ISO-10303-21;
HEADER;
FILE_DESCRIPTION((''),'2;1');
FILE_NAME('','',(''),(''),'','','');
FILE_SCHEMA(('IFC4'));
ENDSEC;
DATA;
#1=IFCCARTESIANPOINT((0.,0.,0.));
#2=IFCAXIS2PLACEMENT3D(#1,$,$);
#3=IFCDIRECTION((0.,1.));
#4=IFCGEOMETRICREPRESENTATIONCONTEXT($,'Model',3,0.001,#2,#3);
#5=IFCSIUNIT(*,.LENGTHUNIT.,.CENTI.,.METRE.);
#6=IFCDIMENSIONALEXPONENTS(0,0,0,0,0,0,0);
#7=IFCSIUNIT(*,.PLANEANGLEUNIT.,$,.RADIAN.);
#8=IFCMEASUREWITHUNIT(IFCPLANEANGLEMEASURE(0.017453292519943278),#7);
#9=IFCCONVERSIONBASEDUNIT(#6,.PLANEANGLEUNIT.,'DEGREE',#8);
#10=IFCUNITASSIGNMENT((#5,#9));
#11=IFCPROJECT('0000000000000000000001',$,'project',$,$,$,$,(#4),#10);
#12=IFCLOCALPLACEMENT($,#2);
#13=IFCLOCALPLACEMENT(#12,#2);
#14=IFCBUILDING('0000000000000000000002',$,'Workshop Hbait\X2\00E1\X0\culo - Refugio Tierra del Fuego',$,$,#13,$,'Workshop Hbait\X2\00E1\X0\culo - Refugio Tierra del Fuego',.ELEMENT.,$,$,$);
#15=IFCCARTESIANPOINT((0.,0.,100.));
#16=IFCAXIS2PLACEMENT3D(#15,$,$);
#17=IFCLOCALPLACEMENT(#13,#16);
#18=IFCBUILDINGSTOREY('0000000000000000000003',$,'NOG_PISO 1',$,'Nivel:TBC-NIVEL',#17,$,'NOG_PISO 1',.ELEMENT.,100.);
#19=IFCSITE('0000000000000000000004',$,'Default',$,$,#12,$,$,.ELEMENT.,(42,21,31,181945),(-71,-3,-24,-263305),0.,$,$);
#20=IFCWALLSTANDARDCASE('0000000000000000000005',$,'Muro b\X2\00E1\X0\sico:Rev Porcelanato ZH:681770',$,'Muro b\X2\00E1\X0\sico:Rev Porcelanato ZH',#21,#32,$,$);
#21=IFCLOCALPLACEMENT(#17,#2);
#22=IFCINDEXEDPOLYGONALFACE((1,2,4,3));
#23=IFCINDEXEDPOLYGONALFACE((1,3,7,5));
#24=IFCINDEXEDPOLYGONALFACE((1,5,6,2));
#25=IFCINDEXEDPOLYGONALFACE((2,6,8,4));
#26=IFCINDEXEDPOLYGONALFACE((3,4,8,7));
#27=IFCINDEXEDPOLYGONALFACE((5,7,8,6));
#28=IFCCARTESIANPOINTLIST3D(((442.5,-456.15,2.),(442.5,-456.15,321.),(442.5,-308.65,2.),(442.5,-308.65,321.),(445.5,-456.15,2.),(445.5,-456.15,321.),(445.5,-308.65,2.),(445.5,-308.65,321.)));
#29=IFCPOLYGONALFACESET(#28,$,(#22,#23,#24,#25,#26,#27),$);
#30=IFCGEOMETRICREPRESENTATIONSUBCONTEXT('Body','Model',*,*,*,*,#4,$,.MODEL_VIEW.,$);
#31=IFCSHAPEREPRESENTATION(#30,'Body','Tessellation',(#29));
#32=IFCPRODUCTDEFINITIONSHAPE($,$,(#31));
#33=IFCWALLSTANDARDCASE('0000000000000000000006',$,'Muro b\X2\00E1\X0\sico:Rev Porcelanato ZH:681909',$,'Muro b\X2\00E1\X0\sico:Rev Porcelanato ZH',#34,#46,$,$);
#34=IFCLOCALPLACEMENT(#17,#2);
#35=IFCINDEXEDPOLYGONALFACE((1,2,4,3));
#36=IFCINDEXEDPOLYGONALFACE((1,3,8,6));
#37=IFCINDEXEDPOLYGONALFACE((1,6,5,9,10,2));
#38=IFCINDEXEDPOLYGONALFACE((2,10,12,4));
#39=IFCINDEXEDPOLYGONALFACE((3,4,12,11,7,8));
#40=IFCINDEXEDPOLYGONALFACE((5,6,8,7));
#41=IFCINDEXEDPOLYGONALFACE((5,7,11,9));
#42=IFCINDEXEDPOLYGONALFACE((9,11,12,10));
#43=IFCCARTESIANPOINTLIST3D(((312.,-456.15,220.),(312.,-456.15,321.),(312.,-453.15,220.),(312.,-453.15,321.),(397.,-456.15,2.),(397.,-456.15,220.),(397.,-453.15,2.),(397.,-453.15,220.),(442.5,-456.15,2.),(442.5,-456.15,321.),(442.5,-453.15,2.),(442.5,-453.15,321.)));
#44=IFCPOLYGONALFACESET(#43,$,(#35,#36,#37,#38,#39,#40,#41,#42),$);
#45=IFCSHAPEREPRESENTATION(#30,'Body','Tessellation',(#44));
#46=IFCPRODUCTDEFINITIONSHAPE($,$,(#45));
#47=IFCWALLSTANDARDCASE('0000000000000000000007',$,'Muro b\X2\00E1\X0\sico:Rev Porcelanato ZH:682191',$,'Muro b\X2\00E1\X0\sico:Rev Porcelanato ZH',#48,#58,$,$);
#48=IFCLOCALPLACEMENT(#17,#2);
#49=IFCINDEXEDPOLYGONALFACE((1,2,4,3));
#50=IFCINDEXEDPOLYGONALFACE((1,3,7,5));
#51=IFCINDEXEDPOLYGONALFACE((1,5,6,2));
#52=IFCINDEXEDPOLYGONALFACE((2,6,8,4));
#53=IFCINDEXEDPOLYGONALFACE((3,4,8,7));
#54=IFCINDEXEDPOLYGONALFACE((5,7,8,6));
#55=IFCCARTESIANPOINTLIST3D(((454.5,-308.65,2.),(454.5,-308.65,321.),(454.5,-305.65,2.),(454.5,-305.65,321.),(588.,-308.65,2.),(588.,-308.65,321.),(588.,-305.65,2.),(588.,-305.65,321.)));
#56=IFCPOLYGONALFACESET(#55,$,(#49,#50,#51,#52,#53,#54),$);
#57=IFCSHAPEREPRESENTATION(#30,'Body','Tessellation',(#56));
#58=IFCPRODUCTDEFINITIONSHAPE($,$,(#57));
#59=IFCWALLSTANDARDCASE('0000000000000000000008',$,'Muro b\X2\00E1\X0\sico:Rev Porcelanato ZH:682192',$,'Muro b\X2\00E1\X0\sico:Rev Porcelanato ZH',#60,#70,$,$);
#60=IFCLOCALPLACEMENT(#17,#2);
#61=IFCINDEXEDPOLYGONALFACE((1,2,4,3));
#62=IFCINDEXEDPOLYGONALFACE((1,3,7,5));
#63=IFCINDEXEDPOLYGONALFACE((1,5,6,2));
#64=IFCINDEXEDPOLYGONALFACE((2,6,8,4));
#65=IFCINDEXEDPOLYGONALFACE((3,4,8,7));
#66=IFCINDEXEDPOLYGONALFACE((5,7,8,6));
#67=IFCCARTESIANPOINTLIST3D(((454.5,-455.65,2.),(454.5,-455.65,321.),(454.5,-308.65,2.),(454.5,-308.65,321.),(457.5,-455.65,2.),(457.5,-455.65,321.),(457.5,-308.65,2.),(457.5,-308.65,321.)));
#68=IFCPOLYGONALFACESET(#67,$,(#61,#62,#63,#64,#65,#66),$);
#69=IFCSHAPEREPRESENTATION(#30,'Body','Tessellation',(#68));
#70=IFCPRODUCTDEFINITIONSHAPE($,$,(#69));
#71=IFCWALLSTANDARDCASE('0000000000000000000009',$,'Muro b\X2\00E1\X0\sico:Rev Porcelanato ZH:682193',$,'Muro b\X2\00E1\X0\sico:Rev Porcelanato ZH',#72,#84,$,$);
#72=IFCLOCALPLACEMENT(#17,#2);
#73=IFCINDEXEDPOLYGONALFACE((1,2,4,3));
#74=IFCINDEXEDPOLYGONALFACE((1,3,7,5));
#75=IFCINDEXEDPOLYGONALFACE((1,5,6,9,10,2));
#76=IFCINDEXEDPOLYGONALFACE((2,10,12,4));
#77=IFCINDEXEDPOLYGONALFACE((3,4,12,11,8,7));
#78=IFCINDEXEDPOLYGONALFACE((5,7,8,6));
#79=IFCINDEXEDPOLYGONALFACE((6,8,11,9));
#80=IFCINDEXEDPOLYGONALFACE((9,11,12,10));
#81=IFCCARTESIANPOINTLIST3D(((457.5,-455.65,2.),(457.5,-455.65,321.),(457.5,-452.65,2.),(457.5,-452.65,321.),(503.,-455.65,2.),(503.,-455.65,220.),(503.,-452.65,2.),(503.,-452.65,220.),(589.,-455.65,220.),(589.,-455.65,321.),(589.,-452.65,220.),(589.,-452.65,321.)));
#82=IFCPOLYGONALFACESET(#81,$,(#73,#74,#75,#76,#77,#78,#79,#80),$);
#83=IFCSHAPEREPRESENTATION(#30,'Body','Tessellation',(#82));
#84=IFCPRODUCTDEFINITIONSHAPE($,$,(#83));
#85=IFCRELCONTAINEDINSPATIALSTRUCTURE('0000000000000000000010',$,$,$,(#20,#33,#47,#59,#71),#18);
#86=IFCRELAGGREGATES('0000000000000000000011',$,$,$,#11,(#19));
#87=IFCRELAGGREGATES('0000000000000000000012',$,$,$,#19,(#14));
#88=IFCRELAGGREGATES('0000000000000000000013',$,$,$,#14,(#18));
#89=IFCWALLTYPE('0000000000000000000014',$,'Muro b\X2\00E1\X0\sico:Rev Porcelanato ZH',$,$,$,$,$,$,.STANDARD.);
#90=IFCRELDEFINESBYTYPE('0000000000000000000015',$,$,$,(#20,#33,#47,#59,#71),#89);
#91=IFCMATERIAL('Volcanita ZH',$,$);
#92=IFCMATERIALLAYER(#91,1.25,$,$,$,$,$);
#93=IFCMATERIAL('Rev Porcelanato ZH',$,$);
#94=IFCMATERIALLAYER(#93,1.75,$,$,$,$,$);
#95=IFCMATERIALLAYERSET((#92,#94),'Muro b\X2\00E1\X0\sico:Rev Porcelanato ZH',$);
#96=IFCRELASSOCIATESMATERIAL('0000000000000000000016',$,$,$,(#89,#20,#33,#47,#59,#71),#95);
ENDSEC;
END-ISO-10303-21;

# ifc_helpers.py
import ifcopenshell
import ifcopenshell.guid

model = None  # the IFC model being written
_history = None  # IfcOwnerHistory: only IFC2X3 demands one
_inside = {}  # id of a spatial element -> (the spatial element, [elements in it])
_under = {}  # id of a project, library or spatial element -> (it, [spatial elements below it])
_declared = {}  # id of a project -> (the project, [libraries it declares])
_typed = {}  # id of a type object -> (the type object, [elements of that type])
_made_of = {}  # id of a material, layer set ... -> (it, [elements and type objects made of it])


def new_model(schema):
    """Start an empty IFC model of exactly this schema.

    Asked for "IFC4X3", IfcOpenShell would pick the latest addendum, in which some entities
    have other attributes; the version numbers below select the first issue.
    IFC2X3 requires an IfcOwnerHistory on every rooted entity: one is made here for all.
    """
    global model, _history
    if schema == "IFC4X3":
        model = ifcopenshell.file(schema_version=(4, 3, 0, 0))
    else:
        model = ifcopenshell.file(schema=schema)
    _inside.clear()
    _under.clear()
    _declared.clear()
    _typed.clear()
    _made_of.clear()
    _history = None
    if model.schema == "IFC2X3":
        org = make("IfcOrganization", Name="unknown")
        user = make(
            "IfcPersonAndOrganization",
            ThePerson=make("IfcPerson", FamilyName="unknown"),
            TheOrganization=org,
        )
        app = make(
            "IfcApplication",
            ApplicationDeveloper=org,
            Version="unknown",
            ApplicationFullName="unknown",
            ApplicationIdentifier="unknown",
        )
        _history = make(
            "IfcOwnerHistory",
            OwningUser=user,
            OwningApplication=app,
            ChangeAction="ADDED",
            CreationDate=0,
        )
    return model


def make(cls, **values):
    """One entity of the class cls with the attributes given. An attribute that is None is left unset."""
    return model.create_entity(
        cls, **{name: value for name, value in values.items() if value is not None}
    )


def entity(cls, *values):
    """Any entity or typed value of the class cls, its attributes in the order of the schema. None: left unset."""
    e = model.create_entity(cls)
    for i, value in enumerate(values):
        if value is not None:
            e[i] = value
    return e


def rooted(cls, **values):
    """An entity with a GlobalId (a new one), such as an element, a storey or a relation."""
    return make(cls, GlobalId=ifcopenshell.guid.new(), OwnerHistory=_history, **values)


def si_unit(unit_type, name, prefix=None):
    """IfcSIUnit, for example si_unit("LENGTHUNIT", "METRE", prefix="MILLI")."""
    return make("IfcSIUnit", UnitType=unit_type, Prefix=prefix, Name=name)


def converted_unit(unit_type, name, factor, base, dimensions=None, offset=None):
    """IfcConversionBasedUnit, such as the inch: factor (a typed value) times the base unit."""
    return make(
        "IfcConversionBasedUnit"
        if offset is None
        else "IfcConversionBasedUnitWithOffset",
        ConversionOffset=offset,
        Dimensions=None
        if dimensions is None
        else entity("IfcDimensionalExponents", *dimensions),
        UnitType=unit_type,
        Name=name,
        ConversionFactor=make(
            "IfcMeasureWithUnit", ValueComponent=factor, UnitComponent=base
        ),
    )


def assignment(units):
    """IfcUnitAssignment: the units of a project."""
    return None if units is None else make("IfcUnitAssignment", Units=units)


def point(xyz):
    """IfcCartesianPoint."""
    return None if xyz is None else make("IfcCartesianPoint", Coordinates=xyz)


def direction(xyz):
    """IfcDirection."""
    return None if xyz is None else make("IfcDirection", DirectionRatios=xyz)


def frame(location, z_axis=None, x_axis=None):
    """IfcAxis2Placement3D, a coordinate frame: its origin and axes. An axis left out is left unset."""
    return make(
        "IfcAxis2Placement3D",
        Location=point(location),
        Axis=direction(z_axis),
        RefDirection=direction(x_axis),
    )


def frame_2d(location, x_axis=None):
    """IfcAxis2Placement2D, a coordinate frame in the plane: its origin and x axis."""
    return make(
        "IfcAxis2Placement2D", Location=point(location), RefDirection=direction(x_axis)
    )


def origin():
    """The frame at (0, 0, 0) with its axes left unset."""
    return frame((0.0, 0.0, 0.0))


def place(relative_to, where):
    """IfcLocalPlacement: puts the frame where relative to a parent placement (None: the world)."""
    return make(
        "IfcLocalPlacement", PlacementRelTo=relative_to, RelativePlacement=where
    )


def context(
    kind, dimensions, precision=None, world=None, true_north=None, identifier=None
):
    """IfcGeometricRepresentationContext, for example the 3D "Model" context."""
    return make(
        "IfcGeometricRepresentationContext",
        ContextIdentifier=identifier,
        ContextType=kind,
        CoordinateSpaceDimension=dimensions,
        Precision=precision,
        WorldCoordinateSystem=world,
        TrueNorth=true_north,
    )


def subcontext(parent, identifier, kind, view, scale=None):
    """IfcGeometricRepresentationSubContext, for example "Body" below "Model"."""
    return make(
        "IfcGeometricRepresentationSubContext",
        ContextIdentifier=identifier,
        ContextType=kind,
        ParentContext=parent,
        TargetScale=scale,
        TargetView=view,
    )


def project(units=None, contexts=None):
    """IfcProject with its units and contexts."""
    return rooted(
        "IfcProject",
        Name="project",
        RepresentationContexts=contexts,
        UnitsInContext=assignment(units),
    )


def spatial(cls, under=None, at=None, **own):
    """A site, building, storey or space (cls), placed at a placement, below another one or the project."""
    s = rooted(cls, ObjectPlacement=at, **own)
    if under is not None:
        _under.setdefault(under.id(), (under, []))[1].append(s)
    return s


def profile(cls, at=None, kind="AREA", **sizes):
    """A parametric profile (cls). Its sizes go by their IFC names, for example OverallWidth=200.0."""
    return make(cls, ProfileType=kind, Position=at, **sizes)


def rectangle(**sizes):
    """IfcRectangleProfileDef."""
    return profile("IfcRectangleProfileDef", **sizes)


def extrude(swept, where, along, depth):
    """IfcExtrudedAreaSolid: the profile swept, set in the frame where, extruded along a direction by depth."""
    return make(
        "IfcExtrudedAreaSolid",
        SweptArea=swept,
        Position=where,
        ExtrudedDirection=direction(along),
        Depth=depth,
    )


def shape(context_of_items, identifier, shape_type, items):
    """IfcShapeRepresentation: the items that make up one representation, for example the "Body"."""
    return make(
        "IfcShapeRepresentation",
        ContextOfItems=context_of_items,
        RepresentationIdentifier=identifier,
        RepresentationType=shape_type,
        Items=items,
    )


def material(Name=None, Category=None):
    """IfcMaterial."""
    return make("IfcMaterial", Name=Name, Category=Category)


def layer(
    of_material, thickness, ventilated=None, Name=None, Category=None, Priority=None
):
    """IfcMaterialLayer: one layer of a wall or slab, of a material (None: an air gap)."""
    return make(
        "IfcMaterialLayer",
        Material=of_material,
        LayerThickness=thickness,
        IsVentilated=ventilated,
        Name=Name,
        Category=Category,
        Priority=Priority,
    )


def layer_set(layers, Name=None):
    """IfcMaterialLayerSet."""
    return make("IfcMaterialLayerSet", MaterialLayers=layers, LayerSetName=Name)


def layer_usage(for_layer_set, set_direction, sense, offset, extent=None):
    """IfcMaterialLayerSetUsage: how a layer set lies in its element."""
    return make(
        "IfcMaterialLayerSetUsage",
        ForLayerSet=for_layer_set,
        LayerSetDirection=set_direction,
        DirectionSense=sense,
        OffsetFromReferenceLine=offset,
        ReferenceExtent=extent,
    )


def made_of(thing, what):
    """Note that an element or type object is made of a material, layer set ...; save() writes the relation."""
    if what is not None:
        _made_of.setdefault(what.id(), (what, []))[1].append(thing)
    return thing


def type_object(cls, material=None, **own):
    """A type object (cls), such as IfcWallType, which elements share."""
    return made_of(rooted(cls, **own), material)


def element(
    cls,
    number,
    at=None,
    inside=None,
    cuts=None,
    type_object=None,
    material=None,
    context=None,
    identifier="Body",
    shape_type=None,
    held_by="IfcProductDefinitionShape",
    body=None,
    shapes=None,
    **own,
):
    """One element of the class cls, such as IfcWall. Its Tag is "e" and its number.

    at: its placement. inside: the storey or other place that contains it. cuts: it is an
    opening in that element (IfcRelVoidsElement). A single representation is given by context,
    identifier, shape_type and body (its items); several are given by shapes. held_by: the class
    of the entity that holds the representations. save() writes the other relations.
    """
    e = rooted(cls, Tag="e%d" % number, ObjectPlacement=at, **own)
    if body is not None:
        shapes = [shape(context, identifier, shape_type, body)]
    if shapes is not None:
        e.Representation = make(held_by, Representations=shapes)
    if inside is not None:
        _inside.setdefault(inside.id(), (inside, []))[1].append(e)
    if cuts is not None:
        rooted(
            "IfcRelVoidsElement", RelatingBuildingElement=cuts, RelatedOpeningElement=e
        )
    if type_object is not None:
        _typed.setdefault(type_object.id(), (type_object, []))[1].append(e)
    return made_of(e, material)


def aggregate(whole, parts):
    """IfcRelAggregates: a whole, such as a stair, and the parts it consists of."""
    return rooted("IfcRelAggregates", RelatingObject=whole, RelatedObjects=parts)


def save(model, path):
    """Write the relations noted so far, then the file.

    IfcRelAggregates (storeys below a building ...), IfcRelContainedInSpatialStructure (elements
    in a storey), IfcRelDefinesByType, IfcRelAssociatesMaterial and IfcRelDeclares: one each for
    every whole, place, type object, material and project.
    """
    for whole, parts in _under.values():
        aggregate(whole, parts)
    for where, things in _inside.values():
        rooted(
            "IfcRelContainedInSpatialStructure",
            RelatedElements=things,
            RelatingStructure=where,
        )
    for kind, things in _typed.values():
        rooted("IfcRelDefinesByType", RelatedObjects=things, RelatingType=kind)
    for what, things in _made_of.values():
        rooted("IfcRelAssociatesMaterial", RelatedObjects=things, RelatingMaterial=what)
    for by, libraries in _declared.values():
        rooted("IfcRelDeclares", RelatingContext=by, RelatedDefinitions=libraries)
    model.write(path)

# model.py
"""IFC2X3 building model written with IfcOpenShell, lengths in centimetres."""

from ifc_helpers import new_model, entity, si_unit, converted_unit, direction, frame, frame_2d, origin, place, context, subcontext, project, spatial, rectangle, extrude, material, layer, layer_set, layer_usage, type_object, element, save


model = new_model("IFC2X3")

# Units and contexts
model_context = context("Model", 3, precision=0.001, world=origin(), true_north=direction((0.0, 1.0)))
body_context = subcontext(model_context, "Body", "Model", "MODEL_VIEW")
ifc_project = project(units=[si_unit("LENGTHUNIT", "METRE", prefix="CENTI"), converted_unit("PLANEANGLEUNIT", "DEGREE", entity("IfcPlaneAngleMeasure", 0.017453292519943278), si_unit("PLANEANGLEUNIT", "RADIAN"), dimensions=[0, 0, 0, 0, 0, 0, 0])], contexts=[model_context])

# Site, building, storey
site_placement = place(None, origin())
site = spatial("IfcSite", under=ifc_project, at=site_placement, Name="Default", CompositionType="ELEMENT", RefLatitude=(42, 21, 31, 181945), RefLongitude=(-71, -3, -24, -263305), RefElevation=0.0)
building_placement = place(site_placement, origin())
building = spatial("IfcBuilding", under=site, at=building_placement, Name="Workshop Hbaitáculo - Refugio Tierra del Fuego", LongName="Workshop Hbaitáculo - Refugio Tierra del Fuego", CompositionType="ELEMENT")
storey_placement = place(building_placement, frame((0.0, 0.0, 100.0)))
storey = spatial("IfcBuildingStorey", under=building, at=storey_placement, Name="NOG_PISO 1", ObjectType="Nivel:TBC-NIVEL", LongName="NOG_PISO 1", CompositionType="ELEMENT", Elevation=100.0)

# Wall
ifc_material_1 = material(Name="Volcanita ZH")
ifc_layer_1 = layer(ifc_material_1, 1.25)
ifc_material_2 = material(Name="Rev Porcelanato ZH")
ifc_layer_2 = layer(ifc_material_2, 1.75)
ifc_layer_set_1 = layer_set([ifc_layer_1, ifc_layer_2], Name="Muro básico:Rev Porcelanato ZH")
wall_type_1 = type_object("IfcWallType", Name="Muro básico:Rev Porcelanato ZH", PredefinedType="STANDARD", material=ifc_layer_set_1)
ifc_layer_usage_1 = layer_usage(ifc_layer_set_1, "AXIS2", "NEGATIVE", 1.5)
wall_1_placement = place(storey_placement, frame((444.0, -308.65, 2.0), z_axis=(0.0, 0.0, 1.0), x_axis=(0.0, -1.0, 0.0)))
element("IfcWallStandardCase", 1, at=wall_1_placement, inside=storey, type_object=wall_type_1, material=ifc_layer_usage_1, Name="Muro básico:Rev Porcelanato ZH:681770", ObjectType="Muro básico:Rev Porcelanato ZH", context=body_context, shape_type="SweptSolid", body=[
    extrude(rectangle(XDim=147.5, YDim=3.0, at=frame_2d((73.75, 0.0), x_axis=(-1.0, 0.0))), origin(), (0.0, 0.0, 1.0), 319.0),
])

# Wall, opening
ifc_layer_usage_2 = layer_usage(ifc_layer_set_1, "AXIS2", "NEGATIVE", 1.5)
wall_2_placement = place(storey_placement, frame((442.5, -454.65, 2.0), z_axis=(0.0, 0.0, 1.0), x_axis=(-1.0, 0.0, 0.0)))
wall_2 = element("IfcWallStandardCase", 2, at=wall_2_placement, inside=storey, type_object=wall_type_1, material=ifc_layer_usage_2, Name="Muro básico:Rev Porcelanato ZH:681909", ObjectType="Muro básico:Rev Porcelanato ZH", context=body_context, shape_type="SweptSolid", body=[
    extrude(rectangle(XDim=130.5, YDim=3.0, at=frame_2d((65.25, 0.0), x_axis=(-1.0, 0.0))), origin(), (0.0, 0.0, 1.0), 319.0),
])
opening_1_placement = place(wall_2_placement, origin())
element("IfcOpeningElement", 3, at=opening_1_placement, cuts=wall_2, ObjectType="Opening", context=body_context, shape_type="SweptSolid", body=[
    extrude(rectangle(XDim=218.0, YDim=85.0, at=frame_2d((0.0, 0.0), x_axis=(0.0, 1.0))), frame((88.0, 1.5, 109.0), z_axis=(0.0, -1.0, 0.0), x_axis=(1.0, 0.0, 0.0)), (0.0, 0.0, 1.0), 3.0),
])

# Walls
ifc_layer_usage_3 = layer_usage(ifc_layer_set_1, "AXIS2", "POSITIVE", -1.5)
wall_3_placement = place(storey_placement, frame((588.0, -307.15, 2.0), z_axis=(0.0, 0.0, 1.0), x_axis=(-1.0, 0.0, 0.0)))
element("IfcWallStandardCase", 4, at=wall_3_placement, inside=storey, type_object=wall_type_1, material=ifc_layer_usage_3, Name="Muro básico:Rev Porcelanato ZH:682191", ObjectType="Muro básico:Rev Porcelanato ZH", context=body_context, shape_type="SweptSolid", body=[
    extrude(rectangle(XDim=133.5, YDim=3.0, at=frame_2d((66.75, 0.0), x_axis=(-1.0, 0.0))), origin(), (0.0, 0.0, 1.0), 319.0),
])
ifc_layer_usage_4 = layer_usage(ifc_layer_set_1, "AXIS2", "POSITIVE", -1.5)
wall_4_placement = place(storey_placement, frame((456.0, -308.65, 2.0), z_axis=(0.0, 0.0, 1.0), x_axis=(0.0, -1.0, 0.0)))
element("IfcWallStandardCase", 5, at=wall_4_placement, inside=storey, type_object=wall_type_1, material=ifc_layer_usage_4, Name="Muro básico:Rev Porcelanato ZH:682192", ObjectType="Muro básico:Rev Porcelanato ZH", context=body_context, shape_type="SweptSolid", body=[
    extrude(rectangle(XDim=147.0, YDim=3.0, at=frame_2d((73.5, 0.0), x_axis=(-1.0, 0.0))), origin(), (0.0, 0.0, 1.0), 319.0),
])

# Wall, opening
ifc_layer_usage_5 = layer_usage(ifc_layer_set_1, "AXIS2", "POSITIVE", -1.5)
wall_5_placement = place(storey_placement, frame((457.5, -454.15, 2.0)))
wall_5 = element("IfcWallStandardCase", 6, at=wall_5_placement, inside=storey, type_object=wall_type_1, material=ifc_layer_usage_5, Name="Muro básico:Rev Porcelanato ZH:682193", ObjectType="Muro básico:Rev Porcelanato ZH", context=body_context, shape_type="SweptSolid", body=[
    extrude(rectangle(XDim=131.5, YDim=3.0, at=frame_2d((65.75, 0.0), x_axis=(-1.0, 0.0))), origin(), (0.0, 0.0, 1.0), 319.0),
])
opening_2_placement = place(wall_5_placement, origin())
element("IfcOpeningElement", 7, at=opening_2_placement, cuts=wall_5, ObjectType="Opening", context=body_context, shape_type="SweptSolid", body=[
    extrude(rectangle(XDim=218.0, YDim=86.0, at=frame_2d((0.0, 0.0), x_axis=(0.0, 1.0))), frame((88.5, 1.5, 109.0), z_axis=(0.0, -1.0, 0.0), x_axis=(1.0, 0.0, 0.0)), (0.0, 0.0, 1.0), 3.0),
])

save(model, "model.ifc")
